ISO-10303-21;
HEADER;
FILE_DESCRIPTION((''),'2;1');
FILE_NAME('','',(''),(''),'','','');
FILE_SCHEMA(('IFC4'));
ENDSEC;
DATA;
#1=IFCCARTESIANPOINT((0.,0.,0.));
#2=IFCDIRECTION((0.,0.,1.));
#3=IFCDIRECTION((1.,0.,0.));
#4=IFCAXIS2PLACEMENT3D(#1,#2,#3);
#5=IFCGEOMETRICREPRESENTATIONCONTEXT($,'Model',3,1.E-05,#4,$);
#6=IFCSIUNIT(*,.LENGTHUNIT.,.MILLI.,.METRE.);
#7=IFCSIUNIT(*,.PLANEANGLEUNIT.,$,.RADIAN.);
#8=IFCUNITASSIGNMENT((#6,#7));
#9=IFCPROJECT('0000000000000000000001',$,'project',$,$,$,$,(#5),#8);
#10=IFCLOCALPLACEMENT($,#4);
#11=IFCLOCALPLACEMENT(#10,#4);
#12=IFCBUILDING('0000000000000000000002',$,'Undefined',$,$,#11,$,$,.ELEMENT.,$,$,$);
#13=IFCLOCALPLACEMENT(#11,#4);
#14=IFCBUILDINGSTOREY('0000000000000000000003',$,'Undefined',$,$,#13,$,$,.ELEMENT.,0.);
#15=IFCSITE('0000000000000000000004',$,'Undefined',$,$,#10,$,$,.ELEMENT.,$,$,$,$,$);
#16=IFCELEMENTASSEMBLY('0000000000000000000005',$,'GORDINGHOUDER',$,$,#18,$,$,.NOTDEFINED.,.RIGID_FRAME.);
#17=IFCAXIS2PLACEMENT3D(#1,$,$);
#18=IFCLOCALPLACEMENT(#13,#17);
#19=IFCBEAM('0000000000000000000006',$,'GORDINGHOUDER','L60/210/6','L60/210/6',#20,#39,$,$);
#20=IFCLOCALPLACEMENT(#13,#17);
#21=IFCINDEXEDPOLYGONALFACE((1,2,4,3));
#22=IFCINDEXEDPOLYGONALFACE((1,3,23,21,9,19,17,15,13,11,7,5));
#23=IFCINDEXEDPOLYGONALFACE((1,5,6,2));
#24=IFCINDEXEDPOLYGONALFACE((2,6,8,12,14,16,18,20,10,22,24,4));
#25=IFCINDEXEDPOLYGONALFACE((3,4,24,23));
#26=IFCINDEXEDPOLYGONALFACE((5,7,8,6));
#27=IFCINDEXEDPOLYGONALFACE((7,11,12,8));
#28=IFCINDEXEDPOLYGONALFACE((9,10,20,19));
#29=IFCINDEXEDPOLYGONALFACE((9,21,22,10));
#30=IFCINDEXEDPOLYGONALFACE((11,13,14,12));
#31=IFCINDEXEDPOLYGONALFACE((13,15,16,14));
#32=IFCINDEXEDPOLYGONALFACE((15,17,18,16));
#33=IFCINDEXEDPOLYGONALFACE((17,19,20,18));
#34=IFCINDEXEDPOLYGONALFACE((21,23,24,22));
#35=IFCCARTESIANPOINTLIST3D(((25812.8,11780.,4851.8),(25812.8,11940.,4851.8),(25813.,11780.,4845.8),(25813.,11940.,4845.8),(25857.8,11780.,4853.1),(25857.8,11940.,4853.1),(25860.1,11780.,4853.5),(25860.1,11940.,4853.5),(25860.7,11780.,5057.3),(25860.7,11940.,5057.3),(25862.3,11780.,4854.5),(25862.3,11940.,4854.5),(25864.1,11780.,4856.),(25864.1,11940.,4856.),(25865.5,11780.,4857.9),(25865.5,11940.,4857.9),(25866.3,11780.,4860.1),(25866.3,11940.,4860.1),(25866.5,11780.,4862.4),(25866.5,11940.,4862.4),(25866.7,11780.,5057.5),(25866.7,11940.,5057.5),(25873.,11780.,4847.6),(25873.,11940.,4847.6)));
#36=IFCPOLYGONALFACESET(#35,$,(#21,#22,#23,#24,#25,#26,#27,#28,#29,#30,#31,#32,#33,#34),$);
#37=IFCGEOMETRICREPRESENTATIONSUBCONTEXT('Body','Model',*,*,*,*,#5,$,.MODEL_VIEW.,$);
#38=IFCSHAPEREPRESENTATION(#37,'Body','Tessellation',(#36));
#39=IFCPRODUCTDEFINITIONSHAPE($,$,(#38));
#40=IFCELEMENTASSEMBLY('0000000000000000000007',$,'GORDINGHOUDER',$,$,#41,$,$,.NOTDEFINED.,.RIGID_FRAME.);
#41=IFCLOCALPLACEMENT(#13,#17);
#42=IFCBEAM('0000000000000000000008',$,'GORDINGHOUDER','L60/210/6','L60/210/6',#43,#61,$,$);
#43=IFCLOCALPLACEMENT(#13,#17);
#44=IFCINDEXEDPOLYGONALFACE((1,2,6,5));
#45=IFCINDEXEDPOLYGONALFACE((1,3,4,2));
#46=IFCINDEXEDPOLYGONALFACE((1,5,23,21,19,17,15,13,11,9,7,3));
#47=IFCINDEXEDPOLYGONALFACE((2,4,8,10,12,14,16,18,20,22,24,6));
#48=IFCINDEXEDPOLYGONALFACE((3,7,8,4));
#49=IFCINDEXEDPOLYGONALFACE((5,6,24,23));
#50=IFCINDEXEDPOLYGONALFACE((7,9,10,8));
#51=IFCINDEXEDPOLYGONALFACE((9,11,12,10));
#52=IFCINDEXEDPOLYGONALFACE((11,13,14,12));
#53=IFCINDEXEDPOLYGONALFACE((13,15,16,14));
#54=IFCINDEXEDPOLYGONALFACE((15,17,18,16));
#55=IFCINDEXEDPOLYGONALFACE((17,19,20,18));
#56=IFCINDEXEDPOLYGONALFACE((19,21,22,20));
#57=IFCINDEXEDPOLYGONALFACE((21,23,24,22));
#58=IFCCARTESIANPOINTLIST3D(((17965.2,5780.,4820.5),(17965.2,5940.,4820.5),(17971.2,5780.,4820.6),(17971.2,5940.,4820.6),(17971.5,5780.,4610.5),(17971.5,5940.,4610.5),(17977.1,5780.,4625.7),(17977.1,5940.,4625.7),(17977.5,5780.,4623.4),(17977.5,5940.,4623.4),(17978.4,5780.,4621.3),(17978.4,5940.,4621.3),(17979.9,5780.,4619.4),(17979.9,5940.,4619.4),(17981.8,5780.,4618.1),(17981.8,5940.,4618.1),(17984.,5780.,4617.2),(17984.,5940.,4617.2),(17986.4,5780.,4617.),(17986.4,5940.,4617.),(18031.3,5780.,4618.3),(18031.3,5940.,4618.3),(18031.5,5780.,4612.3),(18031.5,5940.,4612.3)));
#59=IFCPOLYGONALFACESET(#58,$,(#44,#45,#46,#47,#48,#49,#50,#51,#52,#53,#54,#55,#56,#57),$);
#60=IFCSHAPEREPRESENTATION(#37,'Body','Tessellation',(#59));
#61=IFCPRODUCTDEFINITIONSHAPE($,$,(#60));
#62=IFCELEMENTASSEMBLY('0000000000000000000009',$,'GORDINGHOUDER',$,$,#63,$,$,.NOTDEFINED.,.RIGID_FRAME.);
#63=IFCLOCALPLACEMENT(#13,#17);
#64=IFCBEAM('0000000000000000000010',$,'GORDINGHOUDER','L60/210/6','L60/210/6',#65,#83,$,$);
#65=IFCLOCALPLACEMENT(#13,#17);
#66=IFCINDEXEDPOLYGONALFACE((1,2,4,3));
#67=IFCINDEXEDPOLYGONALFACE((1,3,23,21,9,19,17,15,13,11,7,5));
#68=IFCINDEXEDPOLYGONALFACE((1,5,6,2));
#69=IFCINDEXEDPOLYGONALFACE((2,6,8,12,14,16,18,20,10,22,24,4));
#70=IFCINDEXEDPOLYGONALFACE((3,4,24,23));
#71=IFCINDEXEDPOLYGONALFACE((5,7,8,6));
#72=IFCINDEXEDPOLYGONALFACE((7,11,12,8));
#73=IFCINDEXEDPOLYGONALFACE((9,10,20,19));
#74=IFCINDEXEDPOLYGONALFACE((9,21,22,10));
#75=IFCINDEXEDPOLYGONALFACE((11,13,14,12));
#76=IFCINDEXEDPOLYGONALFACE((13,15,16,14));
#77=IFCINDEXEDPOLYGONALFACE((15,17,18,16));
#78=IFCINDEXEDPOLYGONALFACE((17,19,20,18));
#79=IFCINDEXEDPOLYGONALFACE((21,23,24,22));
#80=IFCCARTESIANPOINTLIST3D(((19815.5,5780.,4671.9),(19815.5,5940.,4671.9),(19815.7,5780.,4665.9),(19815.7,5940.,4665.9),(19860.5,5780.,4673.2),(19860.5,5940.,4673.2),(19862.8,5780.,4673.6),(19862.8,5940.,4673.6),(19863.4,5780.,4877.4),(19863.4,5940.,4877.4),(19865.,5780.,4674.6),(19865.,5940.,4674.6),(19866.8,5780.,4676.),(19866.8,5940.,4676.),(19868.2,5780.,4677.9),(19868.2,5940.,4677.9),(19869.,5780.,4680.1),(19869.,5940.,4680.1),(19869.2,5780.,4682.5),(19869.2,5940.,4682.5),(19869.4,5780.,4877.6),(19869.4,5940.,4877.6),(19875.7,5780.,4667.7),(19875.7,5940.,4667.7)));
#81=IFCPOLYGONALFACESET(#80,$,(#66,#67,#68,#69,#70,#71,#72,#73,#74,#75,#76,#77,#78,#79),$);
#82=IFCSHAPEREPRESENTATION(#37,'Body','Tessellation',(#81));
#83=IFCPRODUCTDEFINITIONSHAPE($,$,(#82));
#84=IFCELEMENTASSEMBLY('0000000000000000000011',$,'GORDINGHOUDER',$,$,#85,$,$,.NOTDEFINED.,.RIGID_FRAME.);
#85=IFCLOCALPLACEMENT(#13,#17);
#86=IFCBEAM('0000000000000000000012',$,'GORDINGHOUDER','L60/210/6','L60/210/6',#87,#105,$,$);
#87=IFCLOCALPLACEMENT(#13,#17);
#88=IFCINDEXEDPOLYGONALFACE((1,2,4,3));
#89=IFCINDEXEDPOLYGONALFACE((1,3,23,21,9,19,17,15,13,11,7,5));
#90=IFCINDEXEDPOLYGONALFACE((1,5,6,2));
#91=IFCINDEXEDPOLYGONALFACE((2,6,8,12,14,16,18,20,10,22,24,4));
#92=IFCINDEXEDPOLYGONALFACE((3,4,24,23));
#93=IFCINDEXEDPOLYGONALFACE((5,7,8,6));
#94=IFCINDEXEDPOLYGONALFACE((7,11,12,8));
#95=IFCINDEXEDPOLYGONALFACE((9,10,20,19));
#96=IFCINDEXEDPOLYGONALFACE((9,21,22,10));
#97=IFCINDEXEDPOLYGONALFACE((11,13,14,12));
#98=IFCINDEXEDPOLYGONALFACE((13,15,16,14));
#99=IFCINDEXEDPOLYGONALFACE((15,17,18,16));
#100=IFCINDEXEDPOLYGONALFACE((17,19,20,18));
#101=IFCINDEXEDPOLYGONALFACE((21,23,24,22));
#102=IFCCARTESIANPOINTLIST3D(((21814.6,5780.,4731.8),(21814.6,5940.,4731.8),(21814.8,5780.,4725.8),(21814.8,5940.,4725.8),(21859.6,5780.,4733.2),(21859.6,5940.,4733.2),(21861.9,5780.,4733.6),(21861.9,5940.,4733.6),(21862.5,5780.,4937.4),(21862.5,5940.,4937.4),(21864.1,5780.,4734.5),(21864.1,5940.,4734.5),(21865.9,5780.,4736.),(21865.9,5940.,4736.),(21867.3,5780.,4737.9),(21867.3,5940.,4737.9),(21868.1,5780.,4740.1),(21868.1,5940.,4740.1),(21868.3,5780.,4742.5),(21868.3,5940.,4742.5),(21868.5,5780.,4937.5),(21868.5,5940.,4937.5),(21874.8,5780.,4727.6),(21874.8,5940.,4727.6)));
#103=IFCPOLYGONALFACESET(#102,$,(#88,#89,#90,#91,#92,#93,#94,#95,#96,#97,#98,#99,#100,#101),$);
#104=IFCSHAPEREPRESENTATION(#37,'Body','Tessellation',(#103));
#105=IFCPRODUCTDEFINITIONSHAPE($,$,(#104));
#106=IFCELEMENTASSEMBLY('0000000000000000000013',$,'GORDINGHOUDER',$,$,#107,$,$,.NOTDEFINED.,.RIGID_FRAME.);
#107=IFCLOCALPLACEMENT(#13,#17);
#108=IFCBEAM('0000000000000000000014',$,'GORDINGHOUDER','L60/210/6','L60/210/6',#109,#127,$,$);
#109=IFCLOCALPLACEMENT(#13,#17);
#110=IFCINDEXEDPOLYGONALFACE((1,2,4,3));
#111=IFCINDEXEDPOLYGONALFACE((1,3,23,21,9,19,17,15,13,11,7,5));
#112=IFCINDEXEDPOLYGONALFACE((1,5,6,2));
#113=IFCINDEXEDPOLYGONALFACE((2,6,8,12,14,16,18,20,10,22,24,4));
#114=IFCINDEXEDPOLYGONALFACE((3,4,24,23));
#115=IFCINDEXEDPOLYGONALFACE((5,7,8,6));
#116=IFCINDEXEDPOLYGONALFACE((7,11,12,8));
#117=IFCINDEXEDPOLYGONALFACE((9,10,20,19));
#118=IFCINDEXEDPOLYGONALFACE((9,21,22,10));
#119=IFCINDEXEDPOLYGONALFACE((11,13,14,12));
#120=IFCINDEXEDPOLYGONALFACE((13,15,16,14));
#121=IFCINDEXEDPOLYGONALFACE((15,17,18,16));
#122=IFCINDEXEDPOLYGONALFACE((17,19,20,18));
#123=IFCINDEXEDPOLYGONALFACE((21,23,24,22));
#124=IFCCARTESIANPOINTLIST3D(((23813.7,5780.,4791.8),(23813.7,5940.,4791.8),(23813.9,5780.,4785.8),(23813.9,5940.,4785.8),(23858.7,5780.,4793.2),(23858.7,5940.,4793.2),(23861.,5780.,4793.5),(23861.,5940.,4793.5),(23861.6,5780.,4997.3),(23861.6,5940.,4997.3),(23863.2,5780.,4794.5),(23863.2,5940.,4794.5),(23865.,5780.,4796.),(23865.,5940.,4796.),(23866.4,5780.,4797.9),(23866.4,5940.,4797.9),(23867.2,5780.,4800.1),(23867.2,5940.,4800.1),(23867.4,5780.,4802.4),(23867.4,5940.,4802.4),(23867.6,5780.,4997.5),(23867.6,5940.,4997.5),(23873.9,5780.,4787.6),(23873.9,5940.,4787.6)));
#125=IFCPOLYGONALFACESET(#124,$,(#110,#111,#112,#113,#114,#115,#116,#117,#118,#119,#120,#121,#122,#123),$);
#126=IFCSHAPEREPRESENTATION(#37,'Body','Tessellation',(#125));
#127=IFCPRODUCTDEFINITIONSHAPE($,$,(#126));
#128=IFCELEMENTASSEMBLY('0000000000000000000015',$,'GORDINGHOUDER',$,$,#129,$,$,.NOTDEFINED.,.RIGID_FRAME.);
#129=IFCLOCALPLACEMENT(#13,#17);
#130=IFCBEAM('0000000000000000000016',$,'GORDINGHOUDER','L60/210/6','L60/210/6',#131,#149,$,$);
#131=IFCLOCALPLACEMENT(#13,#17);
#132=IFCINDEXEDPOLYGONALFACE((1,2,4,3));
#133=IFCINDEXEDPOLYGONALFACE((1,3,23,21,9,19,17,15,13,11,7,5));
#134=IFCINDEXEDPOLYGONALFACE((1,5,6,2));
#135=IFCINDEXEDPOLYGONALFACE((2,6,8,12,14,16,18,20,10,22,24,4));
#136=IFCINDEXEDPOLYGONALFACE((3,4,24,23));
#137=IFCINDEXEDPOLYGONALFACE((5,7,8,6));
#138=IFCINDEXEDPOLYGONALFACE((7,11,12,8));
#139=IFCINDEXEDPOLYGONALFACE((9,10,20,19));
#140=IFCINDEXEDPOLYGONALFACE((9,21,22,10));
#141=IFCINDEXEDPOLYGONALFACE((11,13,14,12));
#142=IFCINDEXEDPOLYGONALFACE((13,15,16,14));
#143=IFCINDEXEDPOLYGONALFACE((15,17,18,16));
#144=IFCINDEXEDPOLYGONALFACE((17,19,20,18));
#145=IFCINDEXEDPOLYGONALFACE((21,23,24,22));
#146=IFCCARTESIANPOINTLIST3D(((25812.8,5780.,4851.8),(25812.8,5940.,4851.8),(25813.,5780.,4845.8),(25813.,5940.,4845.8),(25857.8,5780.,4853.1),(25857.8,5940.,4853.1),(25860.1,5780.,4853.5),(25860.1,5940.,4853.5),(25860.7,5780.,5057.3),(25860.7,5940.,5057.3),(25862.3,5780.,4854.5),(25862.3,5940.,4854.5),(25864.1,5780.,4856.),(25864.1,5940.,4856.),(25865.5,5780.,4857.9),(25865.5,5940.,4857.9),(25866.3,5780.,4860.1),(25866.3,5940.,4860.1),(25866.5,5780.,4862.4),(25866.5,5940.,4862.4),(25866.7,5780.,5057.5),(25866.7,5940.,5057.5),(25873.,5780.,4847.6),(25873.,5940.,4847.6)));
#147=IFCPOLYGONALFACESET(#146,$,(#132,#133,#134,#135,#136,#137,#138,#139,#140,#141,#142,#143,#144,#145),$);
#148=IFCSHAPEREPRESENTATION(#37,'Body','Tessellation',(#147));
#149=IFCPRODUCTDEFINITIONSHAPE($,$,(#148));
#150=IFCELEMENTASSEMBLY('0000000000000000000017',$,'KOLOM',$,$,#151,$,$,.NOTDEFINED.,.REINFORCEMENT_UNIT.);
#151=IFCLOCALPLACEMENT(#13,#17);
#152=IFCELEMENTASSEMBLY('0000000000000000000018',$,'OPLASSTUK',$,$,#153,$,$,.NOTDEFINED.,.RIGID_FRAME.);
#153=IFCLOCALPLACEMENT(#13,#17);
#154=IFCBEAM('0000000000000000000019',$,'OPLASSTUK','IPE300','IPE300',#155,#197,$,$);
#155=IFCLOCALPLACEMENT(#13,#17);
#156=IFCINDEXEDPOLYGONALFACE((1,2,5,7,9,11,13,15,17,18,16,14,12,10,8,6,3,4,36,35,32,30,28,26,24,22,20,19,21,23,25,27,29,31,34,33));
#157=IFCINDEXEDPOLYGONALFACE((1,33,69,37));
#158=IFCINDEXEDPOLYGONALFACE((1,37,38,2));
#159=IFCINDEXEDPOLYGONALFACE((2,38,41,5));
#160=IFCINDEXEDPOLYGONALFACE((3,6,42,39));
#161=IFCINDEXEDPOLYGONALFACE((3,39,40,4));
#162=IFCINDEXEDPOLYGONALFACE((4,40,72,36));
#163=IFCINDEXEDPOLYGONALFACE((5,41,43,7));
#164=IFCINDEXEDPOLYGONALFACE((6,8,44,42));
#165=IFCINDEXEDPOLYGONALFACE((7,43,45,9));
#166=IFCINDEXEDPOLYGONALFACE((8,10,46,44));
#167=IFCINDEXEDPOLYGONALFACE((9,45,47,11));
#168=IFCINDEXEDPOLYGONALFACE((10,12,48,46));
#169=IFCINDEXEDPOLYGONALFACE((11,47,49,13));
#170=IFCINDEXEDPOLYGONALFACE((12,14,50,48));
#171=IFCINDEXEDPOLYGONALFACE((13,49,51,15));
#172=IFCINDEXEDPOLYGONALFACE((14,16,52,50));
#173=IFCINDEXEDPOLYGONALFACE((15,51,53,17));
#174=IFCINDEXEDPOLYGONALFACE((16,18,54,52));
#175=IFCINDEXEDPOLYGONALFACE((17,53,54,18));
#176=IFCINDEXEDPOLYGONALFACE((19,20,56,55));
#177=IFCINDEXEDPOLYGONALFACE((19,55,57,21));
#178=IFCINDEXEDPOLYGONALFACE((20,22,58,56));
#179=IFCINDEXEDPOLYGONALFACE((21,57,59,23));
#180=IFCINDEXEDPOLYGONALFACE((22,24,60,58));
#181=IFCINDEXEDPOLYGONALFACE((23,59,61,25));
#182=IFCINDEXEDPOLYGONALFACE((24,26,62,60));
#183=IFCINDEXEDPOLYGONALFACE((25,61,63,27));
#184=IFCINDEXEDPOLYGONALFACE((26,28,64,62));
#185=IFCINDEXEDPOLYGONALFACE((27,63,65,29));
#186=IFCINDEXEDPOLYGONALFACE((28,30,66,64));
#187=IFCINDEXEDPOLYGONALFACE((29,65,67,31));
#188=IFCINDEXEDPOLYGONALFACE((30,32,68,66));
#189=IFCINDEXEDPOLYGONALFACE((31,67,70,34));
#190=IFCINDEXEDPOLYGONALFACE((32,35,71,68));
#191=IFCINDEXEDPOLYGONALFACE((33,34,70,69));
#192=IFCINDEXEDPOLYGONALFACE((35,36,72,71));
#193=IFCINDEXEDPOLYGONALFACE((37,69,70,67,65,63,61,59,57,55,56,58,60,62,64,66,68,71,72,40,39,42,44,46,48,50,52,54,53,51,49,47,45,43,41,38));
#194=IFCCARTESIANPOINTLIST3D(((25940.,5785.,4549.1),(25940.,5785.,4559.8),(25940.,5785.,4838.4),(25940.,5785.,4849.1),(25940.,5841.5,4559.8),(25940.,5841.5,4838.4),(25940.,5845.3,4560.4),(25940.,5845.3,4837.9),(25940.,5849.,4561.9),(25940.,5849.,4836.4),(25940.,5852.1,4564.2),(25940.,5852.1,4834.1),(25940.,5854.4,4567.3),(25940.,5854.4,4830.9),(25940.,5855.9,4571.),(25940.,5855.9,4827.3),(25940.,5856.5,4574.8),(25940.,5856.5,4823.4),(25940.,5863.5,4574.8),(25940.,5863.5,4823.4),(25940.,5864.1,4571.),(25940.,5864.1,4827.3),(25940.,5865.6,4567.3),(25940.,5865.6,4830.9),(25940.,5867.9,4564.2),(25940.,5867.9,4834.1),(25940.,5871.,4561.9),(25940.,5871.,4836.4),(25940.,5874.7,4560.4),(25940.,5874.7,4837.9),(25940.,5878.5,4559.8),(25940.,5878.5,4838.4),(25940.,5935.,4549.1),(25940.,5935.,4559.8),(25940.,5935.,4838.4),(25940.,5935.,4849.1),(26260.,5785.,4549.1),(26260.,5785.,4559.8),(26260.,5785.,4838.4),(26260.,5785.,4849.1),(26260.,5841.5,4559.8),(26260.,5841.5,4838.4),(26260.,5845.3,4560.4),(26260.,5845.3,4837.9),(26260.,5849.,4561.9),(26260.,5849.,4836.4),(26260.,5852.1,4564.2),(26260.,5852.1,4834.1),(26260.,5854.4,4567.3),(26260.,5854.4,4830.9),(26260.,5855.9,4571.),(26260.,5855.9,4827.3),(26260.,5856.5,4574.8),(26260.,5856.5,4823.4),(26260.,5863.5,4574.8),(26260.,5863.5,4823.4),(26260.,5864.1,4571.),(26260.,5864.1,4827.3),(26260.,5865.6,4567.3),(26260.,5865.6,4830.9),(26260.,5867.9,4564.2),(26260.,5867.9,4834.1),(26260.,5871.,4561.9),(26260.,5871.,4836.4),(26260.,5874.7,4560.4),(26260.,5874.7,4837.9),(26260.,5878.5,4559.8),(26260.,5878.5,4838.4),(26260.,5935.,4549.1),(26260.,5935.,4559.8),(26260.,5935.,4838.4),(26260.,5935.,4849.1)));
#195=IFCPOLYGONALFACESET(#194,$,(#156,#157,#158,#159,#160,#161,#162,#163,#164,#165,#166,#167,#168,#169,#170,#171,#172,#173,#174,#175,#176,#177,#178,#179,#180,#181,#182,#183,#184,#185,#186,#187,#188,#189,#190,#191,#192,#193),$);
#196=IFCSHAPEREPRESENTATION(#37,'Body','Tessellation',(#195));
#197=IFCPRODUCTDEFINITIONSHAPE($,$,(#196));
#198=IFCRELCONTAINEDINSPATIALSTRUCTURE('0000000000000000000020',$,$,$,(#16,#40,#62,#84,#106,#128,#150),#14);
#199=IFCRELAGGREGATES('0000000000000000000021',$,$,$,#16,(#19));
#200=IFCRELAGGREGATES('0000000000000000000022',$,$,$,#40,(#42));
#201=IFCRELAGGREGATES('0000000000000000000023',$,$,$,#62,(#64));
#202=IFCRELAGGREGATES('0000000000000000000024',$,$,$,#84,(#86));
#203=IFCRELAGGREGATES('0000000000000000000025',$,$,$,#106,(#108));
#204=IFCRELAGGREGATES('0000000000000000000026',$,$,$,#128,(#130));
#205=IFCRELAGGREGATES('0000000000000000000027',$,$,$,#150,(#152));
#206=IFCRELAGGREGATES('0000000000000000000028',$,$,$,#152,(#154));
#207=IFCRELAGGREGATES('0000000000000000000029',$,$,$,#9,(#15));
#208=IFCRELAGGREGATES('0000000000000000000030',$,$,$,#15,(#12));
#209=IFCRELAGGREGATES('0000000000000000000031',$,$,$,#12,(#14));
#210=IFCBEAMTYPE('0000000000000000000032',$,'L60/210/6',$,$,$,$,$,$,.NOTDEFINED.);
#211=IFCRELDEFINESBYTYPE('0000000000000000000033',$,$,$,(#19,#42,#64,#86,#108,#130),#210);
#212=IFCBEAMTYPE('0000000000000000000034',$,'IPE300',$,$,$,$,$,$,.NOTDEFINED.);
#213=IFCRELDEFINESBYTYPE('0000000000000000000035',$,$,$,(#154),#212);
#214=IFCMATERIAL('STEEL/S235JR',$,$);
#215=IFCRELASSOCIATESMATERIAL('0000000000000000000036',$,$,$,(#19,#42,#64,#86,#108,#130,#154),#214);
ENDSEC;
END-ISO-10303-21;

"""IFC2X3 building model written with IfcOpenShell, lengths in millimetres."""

from ifc_helpers import new_model, si_unit, frame, frame_2d, origin_with_axes, place, context, subcontext, project, spatial, i_section, l_section, extrude, clip, halfspace, material, type_object, element, aggregate, save


model = new_model("IFC2X3")

# Units and contexts
model_context = context("Model", 3, precision=1e-05, world=origin_with_axes())
body_context = subcontext(model_context, "Body", "Model", "MODEL_VIEW")
ifc_project = project(units=[si_unit("LENGTHUNIT", "METRE", prefix="MILLI"), si_unit("PLANEANGLEUNIT", "RADIAN")], contexts=[model_context])

# Site, building, storey
site_placement = place(None, origin_with_axes())
site = spatial("IfcSite", under=ifc_project, at=site_placement, Name="Undefined", CompositionType="ELEMENT")
building_placement = place(site_placement, origin_with_axes())
building = spatial("IfcBuilding", under=site, at=building_placement, Name="Undefined", CompositionType="ELEMENT")
storey_placement = place(building_placement, origin_with_axes())
storey = spatial("IfcBuildingStorey", under=building, at=storey_placement, Name="Undefined", CompositionType="ELEMENT", Elevation=0.0)

# Element assemblies, beams
ifc_material_1 = material(Name="STEEL/S235JR")
beam_type_1 = type_object("IfcBeamType", Name="L60/210/6", PredefinedType="NOTDEFINED")
assembly_1_placement = place(storey_placement, origin_with_axes())
assembly_1 = element("IfcElementAssembly", 1, at=assembly_1_placement, inside=storey, Name="GORDINGHOUDER", AssemblyPlace="NOTDEFINED", PredefinedType="RIGID_FRAME")
beam_1_placement = place(assembly_1_placement, frame((25839.8, 11780.0, 4951.6), z_axis=(-0.99955, 0.0, -0.029987), x_axis=(0.0, 1.0, 0.0)))
beam_1 = element("IfcBeam", 2, at=beam_1_placement, type_object=beam_type_1, material=ifc_material_1, Name="GORDINGHOUDER", Description="L60/210/6", ObjectType="L60/210/6", context=body_context, shape_type="SweptSolid", body=[
    extrude(l_section(Depth=60.0, Width=210.0, Thickness=6.0, FilletRadius=9.0, at=frame_2d((0.0, 0.0), x_axis=(1.0, 0.0))), frame((160.0, 0.0, 0.0), z_axis=(-1.0, 0.0, 0.0), x_axis=(0.0, -1.0, 0.0)), (0.0, 0.0, 1.0), 160.0),
])
aggregate(assembly_1, [beam_1])
assembly_2_placement = place(storey_placement, origin_with_axes())
assembly_2 = element("IfcElementAssembly", 3, at=assembly_2_placement, inside=storey, Name="GORDINGHOUDER", AssemblyPlace="NOTDEFINED", PredefinedType="RIGID_FRAME")
beam_2_placement = place(assembly_2_placement, frame((17998.4, 5940.0, 4716.4), z_axis=(0.99955, 0.0, 0.029986), x_axis=(0.0, -1.0, 0.0)))
beam_2 = element("IfcBeam", 4, at=beam_2_placement, type_object=beam_type_1, material=ifc_material_1, Name="GORDINGHOUDER", Description="L60/210/6", ObjectType="L60/210/6", context=body_context, shape_type="SweptSolid", body=[
    extrude(l_section(Depth=60.0, Width=210.0, Thickness=6.0, FilletRadius=9.0, at=frame_2d((0.0, 0.0), x_axis=(1.0, 0.0))), frame((160.0, 0.0, 0.0), z_axis=(-1.0, 0.0, 0.0), x_axis=(0.0, -1.0, 0.0)), (0.0, 0.0, 1.0), 160.0),
])
aggregate(assembly_2, [beam_2])
assembly_3_placement = place(storey_placement, origin_with_axes())
assembly_3 = element("IfcElementAssembly", 5, at=assembly_3_placement, inside=storey, Name="GORDINGHOUDER", AssemblyPlace="NOTDEFINED", PredefinedType="RIGID_FRAME")
beam_3_placement = place(assembly_3_placement, frame((19842.5, 5780.0, 4771.7), z_axis=(-0.99955, 0.0, -0.029987), x_axis=(0.0, 1.0, 0.0)))
beam_3 = element("IfcBeam", 6, at=beam_3_placement, type_object=beam_type_1, material=ifc_material_1, Name="GORDINGHOUDER", Description="L60/210/6", ObjectType="L60/210/6", context=body_context, shape_type="SweptSolid", body=[
    extrude(l_section(Depth=60.0, Width=210.0, Thickness=6.0, FilletRadius=9.0, at=frame_2d((0.0, 0.0), x_axis=(1.0, 0.0))), frame((160.0, 0.0, 0.0), z_axis=(-1.0, 0.0, 0.0), x_axis=(0.0, -1.0, 0.0)), (0.0, 0.0, 1.0), 160.0),
])
aggregate(assembly_3, [beam_3])
assembly_4_placement = place(storey_placement, origin_with_axes())
assembly_4 = element("IfcElementAssembly", 7, at=assembly_4_placement, inside=storey, Name="GORDINGHOUDER", AssemblyPlace="NOTDEFINED", PredefinedType="RIGID_FRAME")
beam_4_placement = place(assembly_4_placement, frame((21841.6, 5780.0, 4831.7), z_axis=(-0.99955, 0.0, -0.029987), x_axis=(0.0, 1.0, 0.0)))
beam_4 = element("IfcBeam", 8, at=beam_4_placement, type_object=beam_type_1, material=ifc_material_1, Name="GORDINGHOUDER", Description="L60/210/6", ObjectType="L60/210/6", context=body_context, shape_type="SweptSolid", body=[
    extrude(l_section(Depth=60.0, Width=210.0, Thickness=6.0, FilletRadius=9.0, at=frame_2d((0.0, 0.0), x_axis=(1.0, 0.0))), frame((160.0, 0.0, 0.0), z_axis=(-1.0, 0.0, 0.0), x_axis=(0.0, -1.0, 0.0)), (0.0, 0.0, 1.0), 160.0),
])
aggregate(assembly_4, [beam_4])
assembly_5_placement = place(storey_placement, origin_with_axes())
assembly_5 = element("IfcElementAssembly", 9, at=assembly_5_placement, inside=storey, Name="GORDINGHOUDER", AssemblyPlace="NOTDEFINED", PredefinedType="RIGID_FRAME")
beam_5_placement = place(assembly_5_placement, frame((23840.7, 5780.0, 4891.7), z_axis=(-0.99955, 0.0, -0.029987), x_axis=(0.0, 1.0, 0.0)))
beam_5 = element("IfcBeam", 10, at=beam_5_placement, type_object=beam_type_1, material=ifc_material_1, Name="GORDINGHOUDER", Description="L60/210/6", ObjectType="L60/210/6", context=body_context, shape_type="SweptSolid", body=[
    extrude(l_section(Depth=60.0, Width=210.0, Thickness=6.0, FilletRadius=9.0, at=frame_2d((0.0, 0.0), x_axis=(1.0, 0.0))), frame((160.0, 0.0, 0.0), z_axis=(-1.0, 0.0, 0.0), x_axis=(0.0, -1.0, 0.0)), (0.0, 0.0, 1.0), 160.0),
])
aggregate(assembly_5, [beam_5])
assembly_6_placement = place(storey_placement, origin_with_axes())
assembly_6 = element("IfcElementAssembly", 11, at=assembly_6_placement, inside=storey, Name="GORDINGHOUDER", AssemblyPlace="NOTDEFINED", PredefinedType="RIGID_FRAME")
beam_6_placement = place(assembly_6_placement, frame((25839.8, 5780.0, 4951.6), z_axis=(-0.99955, 0.0, -0.029987), x_axis=(0.0, 1.0, 0.0)))
beam_6 = element("IfcBeam", 12, at=beam_6_placement, type_object=beam_type_1, material=ifc_material_1, Name="GORDINGHOUDER", Description="L60/210/6", ObjectType="L60/210/6", context=body_context, shape_type="SweptSolid", body=[
    extrude(l_section(Depth=60.0, Width=210.0, Thickness=6.0, FilletRadius=9.0, at=frame_2d((0.0, 0.0), x_axis=(1.0, 0.0))), frame((160.0, 0.0, 0.0), z_axis=(-1.0, 0.0, 0.0), x_axis=(0.0, -1.0, 0.0)), (0.0, 0.0, 1.0), 160.0),
])
aggregate(assembly_6, [beam_6])

# Element assemblies, beam
assembly_7_placement = place(storey_placement, origin_with_axes())
assembly_7 = element("IfcElementAssembly", 13, at=assembly_7_placement, inside=storey, Name="KOLOM", AssemblyPlace="NOTDEFINED", PredefinedType="REINFORCEMENT_UNIT")
assembly_8_placement = place(assembly_7_placement, origin_with_axes())
assembly_8 = element("IfcElementAssembly", 14, at=assembly_8_placement, Name="OPLASSTUK", AssemblyPlace="NOTDEFINED", PredefinedType="RIGID_FRAME")
aggregate(assembly_7, [assembly_8])
beam_type_2 = type_object("IfcBeamType", Name="IPE300", PredefinedType="NOTDEFINED")
beam_7_placement = place(assembly_8_placement, frame((25925.0, 5860.0, 4699.1), z_axis=(0.0, 0.0, 1.0), x_axis=(1.0, 0.0, 0.0)))
beam_7 = element("IfcBeam", 15, at=beam_7_placement, type_object=beam_type_2, material=ifc_material_1, Name="OPLASSTUK", Description="IPE300", ObjectType="IPE300", context=body_context, shape_type="Clipping", body=[
    clip(extrude(i_section(OverallWidth=150.0, OverallDepth=300.0, WebThickness=7.1, FlangeThickness=10.7, FilletRadius=15.0, at=frame_2d((0.0, 0.0), x_axis=(1.0, 0.0))), frame((335.0, 0.0, 0.0), z_axis=(-1.0, 0.0, 0.0), x_axis=(0.0, -1.0, 0.0)), (0.0, 0.0, 1.0), 320.0), halfspace(frame((15.0, 0.0, 1.0), z_axis=(-1.0, 0.0, 0.0), x_axis=(0.0, -1.0, 0.0)), False)),
])

aggregate(assembly_8, [beam_7])

save(model, "model.ifc")
